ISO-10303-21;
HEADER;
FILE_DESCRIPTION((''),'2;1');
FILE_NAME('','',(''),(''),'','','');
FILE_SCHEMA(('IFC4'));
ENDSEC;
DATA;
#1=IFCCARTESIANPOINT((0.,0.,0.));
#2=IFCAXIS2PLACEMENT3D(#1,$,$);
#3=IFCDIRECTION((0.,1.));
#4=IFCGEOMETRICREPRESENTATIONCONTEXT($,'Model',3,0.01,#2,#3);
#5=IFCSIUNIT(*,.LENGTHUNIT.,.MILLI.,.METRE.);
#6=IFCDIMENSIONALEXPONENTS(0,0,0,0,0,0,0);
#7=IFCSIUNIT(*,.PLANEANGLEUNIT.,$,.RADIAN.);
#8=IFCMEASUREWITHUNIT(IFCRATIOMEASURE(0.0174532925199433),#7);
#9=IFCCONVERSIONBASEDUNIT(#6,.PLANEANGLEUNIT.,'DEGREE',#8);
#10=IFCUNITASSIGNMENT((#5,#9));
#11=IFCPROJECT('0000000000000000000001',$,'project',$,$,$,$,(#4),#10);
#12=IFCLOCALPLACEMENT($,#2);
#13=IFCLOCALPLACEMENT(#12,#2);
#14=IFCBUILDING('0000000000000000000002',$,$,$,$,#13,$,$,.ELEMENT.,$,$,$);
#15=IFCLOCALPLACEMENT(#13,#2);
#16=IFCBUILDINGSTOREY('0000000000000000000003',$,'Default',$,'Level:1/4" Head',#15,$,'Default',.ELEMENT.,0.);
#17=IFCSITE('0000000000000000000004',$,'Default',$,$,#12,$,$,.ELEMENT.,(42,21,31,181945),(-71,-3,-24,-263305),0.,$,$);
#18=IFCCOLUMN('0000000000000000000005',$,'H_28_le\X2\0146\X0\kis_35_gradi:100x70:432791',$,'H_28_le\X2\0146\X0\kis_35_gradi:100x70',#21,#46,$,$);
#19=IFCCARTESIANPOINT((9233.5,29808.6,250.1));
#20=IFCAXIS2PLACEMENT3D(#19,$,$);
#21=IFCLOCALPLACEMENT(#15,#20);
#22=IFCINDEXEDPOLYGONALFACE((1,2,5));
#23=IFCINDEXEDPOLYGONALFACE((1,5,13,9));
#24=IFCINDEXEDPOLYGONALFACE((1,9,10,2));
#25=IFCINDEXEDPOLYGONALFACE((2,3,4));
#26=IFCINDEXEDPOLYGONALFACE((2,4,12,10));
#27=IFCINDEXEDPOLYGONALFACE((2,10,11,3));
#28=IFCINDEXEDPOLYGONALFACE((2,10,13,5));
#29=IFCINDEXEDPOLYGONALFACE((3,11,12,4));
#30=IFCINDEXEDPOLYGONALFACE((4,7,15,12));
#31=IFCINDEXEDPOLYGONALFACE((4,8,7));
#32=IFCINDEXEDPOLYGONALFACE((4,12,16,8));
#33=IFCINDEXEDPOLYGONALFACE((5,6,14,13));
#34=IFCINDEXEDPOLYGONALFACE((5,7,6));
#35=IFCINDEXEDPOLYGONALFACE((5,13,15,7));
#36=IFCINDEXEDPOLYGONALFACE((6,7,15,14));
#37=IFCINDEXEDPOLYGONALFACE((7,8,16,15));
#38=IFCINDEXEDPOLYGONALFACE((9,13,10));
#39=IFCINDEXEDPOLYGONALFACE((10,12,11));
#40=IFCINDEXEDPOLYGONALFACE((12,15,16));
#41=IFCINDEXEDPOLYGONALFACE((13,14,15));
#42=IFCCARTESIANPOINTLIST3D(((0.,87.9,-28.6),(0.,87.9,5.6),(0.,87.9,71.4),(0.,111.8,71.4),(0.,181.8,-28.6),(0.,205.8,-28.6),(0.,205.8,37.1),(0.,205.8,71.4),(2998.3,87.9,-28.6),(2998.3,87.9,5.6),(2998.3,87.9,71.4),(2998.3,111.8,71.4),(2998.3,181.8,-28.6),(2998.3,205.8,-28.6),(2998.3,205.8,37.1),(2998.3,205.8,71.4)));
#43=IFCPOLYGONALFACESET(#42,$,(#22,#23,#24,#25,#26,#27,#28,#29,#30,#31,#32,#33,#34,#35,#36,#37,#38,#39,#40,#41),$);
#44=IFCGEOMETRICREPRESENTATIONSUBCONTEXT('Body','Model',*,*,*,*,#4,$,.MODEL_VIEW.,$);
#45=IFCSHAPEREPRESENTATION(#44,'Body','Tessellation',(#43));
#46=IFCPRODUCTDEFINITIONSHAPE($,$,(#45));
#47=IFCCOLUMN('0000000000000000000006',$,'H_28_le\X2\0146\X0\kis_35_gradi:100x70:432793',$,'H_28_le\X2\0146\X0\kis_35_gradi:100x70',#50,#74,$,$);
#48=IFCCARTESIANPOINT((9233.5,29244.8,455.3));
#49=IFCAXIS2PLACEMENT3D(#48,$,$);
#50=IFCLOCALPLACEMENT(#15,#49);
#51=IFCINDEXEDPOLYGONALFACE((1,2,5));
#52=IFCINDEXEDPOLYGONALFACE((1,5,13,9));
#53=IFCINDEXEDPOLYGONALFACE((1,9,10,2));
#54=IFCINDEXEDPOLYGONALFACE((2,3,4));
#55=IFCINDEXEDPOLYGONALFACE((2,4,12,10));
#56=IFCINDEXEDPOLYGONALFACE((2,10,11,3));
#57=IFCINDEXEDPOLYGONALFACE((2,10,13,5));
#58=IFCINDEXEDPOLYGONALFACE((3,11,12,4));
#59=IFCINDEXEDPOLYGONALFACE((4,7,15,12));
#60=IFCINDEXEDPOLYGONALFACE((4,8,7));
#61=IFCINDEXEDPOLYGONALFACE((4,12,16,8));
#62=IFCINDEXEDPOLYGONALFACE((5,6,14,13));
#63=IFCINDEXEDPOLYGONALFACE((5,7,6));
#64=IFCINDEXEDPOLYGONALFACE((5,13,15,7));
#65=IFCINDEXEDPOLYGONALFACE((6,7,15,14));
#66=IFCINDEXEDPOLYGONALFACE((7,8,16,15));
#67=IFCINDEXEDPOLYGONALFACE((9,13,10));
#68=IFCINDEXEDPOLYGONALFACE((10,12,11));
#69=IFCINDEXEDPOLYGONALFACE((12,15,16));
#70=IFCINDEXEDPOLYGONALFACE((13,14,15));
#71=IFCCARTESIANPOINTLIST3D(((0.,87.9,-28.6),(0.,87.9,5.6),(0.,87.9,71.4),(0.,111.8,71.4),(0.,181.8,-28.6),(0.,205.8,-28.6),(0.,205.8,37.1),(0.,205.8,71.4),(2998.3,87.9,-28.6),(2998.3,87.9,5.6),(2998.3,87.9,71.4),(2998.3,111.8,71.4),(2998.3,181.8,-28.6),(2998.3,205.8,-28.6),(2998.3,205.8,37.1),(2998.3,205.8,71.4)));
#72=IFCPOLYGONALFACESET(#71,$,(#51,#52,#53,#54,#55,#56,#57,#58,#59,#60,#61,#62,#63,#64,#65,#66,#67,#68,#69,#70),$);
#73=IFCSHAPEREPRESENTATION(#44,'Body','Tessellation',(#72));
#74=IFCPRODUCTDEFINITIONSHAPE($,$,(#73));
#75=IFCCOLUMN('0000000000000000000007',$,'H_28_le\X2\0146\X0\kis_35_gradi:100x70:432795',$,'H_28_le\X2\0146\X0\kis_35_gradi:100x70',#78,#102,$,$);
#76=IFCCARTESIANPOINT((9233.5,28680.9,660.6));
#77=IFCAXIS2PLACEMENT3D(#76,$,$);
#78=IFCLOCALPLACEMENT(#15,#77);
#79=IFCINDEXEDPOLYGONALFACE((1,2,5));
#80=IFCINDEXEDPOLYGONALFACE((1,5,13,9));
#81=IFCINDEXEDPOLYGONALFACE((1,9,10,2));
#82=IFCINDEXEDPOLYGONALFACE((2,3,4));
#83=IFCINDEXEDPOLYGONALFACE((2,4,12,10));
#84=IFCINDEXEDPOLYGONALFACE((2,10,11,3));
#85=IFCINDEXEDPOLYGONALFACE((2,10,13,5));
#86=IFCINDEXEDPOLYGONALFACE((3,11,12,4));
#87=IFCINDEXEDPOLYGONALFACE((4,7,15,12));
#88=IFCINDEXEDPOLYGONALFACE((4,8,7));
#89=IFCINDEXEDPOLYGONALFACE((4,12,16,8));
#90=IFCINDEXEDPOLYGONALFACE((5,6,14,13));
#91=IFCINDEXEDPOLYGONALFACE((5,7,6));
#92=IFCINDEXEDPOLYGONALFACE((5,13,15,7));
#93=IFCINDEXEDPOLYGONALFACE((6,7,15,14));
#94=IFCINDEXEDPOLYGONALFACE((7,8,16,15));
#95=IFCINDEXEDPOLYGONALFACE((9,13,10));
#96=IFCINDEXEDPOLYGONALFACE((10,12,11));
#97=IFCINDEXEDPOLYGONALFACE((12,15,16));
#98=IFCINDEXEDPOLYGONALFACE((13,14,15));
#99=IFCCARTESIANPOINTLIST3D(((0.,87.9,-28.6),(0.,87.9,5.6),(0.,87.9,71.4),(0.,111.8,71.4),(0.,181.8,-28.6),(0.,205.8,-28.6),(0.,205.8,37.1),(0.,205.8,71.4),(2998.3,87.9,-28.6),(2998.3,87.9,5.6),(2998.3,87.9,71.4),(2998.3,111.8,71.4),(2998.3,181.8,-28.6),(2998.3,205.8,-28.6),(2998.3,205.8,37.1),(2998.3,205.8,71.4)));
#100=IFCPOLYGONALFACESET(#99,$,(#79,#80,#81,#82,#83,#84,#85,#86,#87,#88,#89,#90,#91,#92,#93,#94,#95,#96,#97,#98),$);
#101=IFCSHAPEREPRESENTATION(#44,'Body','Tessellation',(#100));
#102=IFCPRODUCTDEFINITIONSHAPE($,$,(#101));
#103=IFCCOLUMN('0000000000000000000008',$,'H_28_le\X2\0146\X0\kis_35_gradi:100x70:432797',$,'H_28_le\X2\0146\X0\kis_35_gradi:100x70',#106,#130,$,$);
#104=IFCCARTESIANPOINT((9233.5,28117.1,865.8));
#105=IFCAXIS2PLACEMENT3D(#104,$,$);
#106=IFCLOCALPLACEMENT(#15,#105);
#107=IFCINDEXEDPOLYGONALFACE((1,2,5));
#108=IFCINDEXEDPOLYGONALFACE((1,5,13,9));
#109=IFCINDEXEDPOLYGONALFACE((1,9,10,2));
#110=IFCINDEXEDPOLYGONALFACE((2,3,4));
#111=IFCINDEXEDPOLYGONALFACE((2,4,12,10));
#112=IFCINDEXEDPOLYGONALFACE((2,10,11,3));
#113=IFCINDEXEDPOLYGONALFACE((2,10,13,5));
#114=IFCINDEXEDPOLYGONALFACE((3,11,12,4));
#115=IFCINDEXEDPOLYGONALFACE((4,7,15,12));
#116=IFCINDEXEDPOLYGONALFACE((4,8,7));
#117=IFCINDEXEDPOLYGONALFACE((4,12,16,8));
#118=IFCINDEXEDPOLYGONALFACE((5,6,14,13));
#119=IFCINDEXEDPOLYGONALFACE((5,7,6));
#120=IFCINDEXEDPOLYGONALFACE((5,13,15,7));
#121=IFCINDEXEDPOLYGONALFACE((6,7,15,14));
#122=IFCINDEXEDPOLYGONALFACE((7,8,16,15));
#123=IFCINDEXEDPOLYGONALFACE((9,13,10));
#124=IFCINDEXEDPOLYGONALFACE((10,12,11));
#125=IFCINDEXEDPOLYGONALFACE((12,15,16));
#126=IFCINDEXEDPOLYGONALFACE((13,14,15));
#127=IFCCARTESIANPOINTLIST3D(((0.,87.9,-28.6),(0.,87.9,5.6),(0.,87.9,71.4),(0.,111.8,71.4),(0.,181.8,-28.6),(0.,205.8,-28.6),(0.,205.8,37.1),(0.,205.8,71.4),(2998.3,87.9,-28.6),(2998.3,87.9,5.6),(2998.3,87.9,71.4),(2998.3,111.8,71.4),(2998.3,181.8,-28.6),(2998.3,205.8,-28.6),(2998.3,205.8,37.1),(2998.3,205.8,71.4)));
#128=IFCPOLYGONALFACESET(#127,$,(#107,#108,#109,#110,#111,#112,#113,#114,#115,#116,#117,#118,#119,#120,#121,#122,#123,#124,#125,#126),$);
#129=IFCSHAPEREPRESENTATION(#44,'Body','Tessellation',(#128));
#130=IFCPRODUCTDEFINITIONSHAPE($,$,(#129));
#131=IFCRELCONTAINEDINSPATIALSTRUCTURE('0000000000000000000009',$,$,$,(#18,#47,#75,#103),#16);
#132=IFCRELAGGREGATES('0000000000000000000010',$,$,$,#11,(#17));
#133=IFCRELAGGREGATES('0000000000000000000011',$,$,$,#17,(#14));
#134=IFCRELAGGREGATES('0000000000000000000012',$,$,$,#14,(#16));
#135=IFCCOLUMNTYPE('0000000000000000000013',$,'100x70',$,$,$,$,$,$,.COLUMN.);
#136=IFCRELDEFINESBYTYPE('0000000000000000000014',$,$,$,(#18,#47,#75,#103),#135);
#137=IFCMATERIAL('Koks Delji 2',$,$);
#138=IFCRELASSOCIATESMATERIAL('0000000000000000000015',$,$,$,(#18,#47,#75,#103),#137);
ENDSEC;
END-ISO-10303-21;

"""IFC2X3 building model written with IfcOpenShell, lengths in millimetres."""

from ifc_helpers import new_model, entity, si_unit, converted_unit, direction, frame, frame_2d, origin, place, context, subcontext, project, spatial, rectangle, extrude, boolean, source, transform, mapped, material, type_object, type_shapes, element, save


model = new_model("IFC2X3")

# Units and contexts
model_context = context("Model", 3, precision=0.01, world=origin(), true_north=direction((0.0, 1.0)))
body_context = subcontext(model_context, "Body", "Model", "MODEL_VIEW")
ifc_project = project(units=[si_unit("LENGTHUNIT", "METRE", prefix="MILLI"), converted_unit("PLANEANGLEUNIT", "DEGREE", entity("IfcRatioMeasure", 0.0174532925199433), si_unit("PLANEANGLEUNIT", "RADIAN"), dimensions=[0, 0, 0, 0, 0, 0, 0])], contexts=[model_context])

# Site, building, storey
site_placement = place(None, origin())
site = spatial("IfcSite", under=ifc_project, at=site_placement, Name="Default", CompositionType="ELEMENT", RefLatitude=(42, 21, 31, 181945), RefLongitude=(-71, -3, -24, -263305), RefElevation=0.0)
building_placement = place(site_placement, origin())
building = spatial("IfcBuilding", under=site, at=building_placement, CompositionType="ELEMENT")
storey_placement = place(building_placement, origin())
storey = spatial("IfcBuildingStorey", under=building, at=storey_placement, Name="Default", ObjectType="Level:1/4\" Head", LongName="Default", CompositionType="ELEMENT", Elevation=0.0)

# Columns
ifc_material_1 = material(Name="Koks Delji 2")
column_type_1 = type_object("IfcColumnType", Name="100x70", PredefinedType="COLUMN")
shared_shape_1 = source(origin(), body_context, "Body", "CSG", [
    boolean("DIFFERENCE", extrude(rectangle(XDim=2998.3, YDim=117.9, at=frame_2d((0.0, 0.0), x_axis=(1.0, 0.0))), frame((1499.1, 146.8, -28.6)), (0.0, 0.0, 1.0), 100.0), extrude(rectangle(XDim=70.0, YDim=100.0, at=frame_2d((0.0, 0.0), x_axis=(0.0, 1.0))), frame((2998.3, 146.8, 21.4), z_axis=(1.0, 0.0, 0.0), x_axis=(0.0, 0.939693, -0.34202)), (0.0, 0.0, -1.0), 2998.3)),
])
type_shapes(column_type_1, [shared_shape_1])
for number, where, name in (
    (1, (9233.5, 29808.6, 250.1), "H_28_leņkis_35_gradi:100x70:432791"),
    (2, (9233.5, 29244.8, 455.3), "H_28_leņkis_35_gradi:100x70:432793"),
    (3, (9233.5, 28680.9, 660.6), "H_28_leņkis_35_gradi:100x70:432795"),
    (4, (9233.5, 28117.1, 865.8), "H_28_leņkis_35_gradi:100x70:432797"),
):
    element("IfcColumn", number, at=place(storey_placement, frame(where)), inside=storey, type_object=column_type_1, material=ifc_material_1, Name=name, ObjectType="H_28_leņkis_35_gradi:100x70", context=body_context, shape_type="MappedRepresentation", body=[
        mapped(shared_shape_1, transform((0.0, 0.0, 0.0), scale=1.0)),
    ])

save(model, "model.ifc")
